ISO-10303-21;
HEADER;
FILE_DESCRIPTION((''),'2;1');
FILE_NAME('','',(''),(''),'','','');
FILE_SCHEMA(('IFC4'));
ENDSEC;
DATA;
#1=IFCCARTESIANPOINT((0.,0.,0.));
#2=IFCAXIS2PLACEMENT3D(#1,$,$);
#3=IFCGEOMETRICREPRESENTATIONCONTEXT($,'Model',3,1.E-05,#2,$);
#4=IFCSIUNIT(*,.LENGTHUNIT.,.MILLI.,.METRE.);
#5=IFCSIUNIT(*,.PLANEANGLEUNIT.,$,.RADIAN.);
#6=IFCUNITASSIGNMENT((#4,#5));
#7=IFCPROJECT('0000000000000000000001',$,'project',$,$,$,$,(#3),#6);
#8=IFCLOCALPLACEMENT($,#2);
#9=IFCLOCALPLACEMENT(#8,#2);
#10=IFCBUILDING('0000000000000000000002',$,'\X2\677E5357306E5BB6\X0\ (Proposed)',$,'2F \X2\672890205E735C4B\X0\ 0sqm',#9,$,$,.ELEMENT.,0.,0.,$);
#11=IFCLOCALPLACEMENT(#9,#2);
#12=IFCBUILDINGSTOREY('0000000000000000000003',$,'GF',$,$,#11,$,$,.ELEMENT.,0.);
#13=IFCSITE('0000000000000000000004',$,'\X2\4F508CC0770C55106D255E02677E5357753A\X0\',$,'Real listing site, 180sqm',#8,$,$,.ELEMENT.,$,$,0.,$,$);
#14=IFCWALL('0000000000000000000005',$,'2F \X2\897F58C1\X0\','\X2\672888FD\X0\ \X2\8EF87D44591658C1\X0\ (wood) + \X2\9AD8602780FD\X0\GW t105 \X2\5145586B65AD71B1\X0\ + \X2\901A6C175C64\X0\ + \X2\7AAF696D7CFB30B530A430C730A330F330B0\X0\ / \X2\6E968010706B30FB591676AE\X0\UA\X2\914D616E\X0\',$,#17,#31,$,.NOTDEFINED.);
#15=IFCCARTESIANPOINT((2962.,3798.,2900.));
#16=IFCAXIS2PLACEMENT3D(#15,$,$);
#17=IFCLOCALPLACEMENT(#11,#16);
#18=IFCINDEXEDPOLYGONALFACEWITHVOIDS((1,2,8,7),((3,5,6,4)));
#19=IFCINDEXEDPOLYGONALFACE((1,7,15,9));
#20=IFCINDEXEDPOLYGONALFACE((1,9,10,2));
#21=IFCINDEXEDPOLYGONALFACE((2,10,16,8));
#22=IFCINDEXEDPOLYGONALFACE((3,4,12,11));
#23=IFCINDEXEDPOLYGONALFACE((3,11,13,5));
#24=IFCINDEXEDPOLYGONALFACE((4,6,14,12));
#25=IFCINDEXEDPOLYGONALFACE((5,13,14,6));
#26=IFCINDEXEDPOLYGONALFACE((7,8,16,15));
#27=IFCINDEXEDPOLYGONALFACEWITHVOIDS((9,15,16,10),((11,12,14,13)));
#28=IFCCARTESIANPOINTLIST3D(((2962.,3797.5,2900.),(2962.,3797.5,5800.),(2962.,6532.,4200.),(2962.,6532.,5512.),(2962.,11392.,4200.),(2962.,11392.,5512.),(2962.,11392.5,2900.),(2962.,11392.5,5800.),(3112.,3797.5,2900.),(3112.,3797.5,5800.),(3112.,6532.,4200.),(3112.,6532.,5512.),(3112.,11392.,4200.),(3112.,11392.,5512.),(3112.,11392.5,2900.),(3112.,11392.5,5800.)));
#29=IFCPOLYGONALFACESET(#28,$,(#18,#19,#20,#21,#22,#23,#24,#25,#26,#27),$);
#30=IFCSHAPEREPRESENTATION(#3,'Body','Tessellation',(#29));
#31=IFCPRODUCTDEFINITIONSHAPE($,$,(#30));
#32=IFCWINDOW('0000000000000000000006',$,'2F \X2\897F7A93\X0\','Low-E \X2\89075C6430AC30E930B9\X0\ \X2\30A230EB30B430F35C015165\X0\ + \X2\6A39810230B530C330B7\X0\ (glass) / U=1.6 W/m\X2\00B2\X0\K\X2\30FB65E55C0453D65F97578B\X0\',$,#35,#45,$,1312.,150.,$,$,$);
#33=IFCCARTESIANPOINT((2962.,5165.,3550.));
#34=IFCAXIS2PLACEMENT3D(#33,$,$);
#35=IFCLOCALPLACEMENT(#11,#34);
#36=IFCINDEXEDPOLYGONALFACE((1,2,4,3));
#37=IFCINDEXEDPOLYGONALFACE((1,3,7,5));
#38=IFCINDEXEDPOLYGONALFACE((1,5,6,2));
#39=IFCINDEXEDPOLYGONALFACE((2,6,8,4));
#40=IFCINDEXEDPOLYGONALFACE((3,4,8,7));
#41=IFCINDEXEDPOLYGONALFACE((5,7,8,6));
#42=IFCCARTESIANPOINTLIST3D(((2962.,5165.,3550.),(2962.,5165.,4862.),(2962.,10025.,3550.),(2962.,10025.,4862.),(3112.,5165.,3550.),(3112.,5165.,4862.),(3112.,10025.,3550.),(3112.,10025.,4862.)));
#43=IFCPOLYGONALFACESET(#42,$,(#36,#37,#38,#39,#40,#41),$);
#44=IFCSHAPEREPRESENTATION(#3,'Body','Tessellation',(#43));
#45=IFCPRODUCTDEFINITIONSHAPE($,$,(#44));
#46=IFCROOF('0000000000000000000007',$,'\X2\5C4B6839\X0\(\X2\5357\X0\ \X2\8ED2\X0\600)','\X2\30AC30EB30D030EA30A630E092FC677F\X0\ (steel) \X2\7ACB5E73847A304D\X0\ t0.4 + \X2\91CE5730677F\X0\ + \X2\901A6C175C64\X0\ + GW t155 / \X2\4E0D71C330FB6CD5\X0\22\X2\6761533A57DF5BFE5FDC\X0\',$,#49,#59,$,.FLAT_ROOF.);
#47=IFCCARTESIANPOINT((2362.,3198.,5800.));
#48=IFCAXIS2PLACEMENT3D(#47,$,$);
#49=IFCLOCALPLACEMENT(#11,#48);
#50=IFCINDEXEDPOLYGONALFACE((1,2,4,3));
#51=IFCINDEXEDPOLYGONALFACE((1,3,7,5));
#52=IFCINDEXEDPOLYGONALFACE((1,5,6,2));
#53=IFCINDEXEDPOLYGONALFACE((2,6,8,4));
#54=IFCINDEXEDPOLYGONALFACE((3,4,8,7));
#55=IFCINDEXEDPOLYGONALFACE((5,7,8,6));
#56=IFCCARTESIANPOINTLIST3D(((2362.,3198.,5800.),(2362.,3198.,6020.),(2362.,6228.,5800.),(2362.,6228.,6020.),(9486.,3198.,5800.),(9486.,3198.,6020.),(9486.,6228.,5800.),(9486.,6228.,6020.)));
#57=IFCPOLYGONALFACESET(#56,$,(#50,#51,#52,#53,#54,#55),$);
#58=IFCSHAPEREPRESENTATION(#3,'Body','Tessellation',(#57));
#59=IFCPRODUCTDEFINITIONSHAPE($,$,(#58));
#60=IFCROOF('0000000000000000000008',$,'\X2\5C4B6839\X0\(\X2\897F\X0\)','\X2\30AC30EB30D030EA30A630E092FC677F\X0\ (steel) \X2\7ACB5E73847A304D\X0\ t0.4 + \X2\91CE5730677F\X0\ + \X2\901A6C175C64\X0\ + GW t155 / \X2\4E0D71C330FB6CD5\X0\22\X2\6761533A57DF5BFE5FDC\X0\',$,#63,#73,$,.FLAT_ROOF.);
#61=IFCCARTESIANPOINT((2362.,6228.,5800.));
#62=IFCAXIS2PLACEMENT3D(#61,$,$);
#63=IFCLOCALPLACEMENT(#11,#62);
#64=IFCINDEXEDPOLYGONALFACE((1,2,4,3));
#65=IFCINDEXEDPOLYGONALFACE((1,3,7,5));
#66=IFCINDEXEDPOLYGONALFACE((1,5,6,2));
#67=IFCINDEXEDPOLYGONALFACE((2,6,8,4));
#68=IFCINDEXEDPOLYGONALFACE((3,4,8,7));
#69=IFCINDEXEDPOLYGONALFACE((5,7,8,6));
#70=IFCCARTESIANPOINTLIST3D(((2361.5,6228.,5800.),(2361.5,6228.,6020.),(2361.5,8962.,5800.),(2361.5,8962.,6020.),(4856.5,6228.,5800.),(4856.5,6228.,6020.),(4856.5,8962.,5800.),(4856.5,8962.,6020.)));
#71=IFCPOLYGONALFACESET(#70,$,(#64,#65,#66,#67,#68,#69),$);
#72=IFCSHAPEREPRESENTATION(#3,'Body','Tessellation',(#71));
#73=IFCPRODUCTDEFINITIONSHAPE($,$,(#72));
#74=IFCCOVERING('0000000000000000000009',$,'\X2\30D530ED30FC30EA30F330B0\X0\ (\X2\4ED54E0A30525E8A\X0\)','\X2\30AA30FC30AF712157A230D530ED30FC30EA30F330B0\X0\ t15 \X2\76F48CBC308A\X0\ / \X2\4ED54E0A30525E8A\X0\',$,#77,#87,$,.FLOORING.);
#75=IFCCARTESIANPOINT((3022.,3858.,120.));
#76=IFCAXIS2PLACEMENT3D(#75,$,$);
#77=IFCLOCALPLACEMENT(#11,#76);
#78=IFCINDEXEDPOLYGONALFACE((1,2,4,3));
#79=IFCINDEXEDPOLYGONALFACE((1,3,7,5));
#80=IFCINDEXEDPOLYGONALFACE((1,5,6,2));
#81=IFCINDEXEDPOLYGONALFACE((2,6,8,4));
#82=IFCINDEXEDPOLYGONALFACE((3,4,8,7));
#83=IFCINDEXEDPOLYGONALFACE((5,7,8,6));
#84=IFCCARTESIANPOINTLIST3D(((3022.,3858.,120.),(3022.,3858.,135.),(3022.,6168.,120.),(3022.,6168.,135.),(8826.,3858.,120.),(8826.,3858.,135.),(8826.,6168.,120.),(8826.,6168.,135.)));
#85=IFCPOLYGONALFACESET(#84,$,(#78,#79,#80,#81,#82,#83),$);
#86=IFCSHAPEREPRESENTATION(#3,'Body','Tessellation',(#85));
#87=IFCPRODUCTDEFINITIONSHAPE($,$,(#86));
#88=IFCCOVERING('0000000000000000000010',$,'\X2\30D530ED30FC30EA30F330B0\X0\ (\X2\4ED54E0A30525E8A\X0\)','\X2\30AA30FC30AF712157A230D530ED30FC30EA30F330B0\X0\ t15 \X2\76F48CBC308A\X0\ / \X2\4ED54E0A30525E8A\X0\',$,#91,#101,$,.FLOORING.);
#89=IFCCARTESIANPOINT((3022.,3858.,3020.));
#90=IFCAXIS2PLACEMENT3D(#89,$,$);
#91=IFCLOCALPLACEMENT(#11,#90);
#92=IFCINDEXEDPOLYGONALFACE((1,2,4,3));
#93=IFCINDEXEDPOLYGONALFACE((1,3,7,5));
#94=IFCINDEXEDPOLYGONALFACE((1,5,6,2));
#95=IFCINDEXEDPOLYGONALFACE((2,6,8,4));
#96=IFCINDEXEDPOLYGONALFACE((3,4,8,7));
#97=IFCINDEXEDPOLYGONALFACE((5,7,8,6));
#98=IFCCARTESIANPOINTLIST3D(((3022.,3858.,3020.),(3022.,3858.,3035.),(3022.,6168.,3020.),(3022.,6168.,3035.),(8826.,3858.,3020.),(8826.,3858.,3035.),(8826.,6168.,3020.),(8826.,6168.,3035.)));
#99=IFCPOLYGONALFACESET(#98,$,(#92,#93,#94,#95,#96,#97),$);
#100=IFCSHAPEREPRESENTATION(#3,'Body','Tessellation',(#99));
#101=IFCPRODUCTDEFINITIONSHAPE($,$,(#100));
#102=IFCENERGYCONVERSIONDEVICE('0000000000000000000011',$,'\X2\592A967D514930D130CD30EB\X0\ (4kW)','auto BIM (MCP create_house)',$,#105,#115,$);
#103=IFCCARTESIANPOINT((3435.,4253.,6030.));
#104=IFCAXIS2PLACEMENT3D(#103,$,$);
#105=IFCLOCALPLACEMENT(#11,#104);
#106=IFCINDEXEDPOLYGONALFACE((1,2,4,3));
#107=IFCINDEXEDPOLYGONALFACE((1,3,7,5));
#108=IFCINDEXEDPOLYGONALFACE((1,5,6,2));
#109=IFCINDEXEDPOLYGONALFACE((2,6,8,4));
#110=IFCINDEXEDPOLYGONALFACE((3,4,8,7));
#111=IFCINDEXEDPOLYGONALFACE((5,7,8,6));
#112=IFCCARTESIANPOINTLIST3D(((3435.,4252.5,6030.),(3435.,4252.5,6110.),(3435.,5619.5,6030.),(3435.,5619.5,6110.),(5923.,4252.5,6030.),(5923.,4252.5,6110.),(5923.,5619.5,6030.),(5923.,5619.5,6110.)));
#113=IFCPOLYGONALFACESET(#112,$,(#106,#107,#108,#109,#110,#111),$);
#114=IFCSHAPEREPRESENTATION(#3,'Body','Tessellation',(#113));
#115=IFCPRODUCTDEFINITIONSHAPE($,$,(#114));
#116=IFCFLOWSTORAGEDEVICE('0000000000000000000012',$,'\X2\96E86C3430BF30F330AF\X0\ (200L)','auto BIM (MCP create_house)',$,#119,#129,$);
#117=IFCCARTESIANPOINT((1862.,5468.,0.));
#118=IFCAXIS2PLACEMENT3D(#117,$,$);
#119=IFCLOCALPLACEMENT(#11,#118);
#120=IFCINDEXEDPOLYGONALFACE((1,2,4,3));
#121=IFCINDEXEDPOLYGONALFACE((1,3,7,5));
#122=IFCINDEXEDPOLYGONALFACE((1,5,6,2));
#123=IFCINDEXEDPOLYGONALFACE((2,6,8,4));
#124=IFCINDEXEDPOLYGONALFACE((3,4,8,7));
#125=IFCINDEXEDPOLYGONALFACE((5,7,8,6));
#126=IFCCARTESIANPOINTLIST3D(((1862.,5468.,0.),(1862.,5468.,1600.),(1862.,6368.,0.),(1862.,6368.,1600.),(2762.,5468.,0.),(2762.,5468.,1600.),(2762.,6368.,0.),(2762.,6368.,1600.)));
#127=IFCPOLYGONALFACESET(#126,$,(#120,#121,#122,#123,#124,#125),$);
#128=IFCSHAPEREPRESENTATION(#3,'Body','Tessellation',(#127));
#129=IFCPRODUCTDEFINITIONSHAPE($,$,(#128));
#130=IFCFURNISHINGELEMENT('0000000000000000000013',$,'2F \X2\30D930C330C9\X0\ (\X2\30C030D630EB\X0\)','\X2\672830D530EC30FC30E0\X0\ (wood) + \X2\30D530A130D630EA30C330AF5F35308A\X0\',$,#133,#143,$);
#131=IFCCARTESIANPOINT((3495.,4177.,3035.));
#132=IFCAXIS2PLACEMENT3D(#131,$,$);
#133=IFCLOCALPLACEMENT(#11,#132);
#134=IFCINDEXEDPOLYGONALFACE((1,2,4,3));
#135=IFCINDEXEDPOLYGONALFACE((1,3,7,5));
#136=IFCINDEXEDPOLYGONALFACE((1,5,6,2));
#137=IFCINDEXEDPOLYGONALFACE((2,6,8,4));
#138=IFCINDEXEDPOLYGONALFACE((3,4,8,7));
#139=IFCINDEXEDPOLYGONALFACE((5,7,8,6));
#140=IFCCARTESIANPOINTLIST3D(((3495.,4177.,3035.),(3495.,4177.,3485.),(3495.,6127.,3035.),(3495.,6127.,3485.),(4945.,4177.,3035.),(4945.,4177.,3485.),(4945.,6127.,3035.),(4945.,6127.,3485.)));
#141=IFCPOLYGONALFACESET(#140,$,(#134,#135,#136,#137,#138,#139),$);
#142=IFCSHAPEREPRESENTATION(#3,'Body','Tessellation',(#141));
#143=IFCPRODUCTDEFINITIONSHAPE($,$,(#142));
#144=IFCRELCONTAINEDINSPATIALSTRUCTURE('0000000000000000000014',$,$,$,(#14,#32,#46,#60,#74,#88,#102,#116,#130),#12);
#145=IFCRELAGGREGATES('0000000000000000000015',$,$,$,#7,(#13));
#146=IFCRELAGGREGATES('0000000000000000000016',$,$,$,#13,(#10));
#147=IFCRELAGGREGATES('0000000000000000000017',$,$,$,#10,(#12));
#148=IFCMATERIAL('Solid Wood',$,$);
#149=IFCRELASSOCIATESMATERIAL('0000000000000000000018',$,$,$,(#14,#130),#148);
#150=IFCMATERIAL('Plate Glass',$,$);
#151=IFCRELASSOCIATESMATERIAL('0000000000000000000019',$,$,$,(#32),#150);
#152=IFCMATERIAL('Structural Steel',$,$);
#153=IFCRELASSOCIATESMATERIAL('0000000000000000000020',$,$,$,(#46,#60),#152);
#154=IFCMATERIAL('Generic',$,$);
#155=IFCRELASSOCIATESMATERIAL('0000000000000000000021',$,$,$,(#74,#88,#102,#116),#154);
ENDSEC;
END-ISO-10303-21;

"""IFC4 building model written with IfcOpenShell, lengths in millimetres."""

from ifc_helpers import new_model, si_unit, frame, frame_2d, origin, place, context, project, spatial, rectangle, extrude, material, element, fill, save


model = new_model("IFC4")

# Units and contexts
model_context = context("Model", 3, precision=1e-05, world=origin())
ifc_project = project(units=[si_unit("LENGTHUNIT", "METRE", prefix="MILLI"), si_unit("PLANEANGLEUNIT", "RADIAN")], contexts=[model_context])

# Site, building, storey
site_placement = place(None, origin())
site = spatial("IfcSite", under=ifc_project, at=site_placement, Name="佐賀県唐津市松南町", ObjectType="Real listing site, 180sqm", CompositionType="ELEMENT", RefElevation=0.0)
building_placement = place(site_placement, origin())
building = spatial("IfcBuilding", under=site, at=building_placement, Name="松南の家 (Proposed)", ObjectType="2F 木造平屋 0sqm", CompositionType="ELEMENT", ElevationOfRefHeight=0.0, ElevationOfTerrain=0.0)
storey_placement = place(building_placement, origin())
storey = spatial("IfcBuildingStorey", under=building, at=storey_placement, Name="GF", CompositionType="ELEMENT", Elevation=0.0)

# Shared definitions
ifc_material_1 = material(Name="Solid Wood")

# Shared definitions
ifc_material_2 = material(Name="Plate Glass")

# Wall, opening, window
wall_1_placement = place(storey_placement, frame((2962.0, 3798.0, 2900.0)))
wall_1 = element("IfcWall", 1, at=wall_1_placement, inside=storey, material=ifc_material_1, Name="2F 西壁", Description="木製 軸組外壁 (wood) + 高性能GW t105 充填断熱 + 通気層 + 窯業系サイディング / 準耐火・外皮UA配慮", PredefinedType="NOTDEFINED", context=model_context, shape_type="SweptSolid", body=[
    extrude(rectangle(XDim=150.0, YDim=7595.0, at=frame_2d((75.0, 3797.0))), frame((2962.0, 3798.0, 2900.0)), (0.0, 0.0, 1.0), 2900.0),
])
opening_1_placement = place(storey_placement, frame((2962.0, 5165.0, 3550.0)))
opening_1 = element("IfcOpeningElement", 2, at=opening_1_placement, cuts=wall_1, PredefinedType="NOTDEFINED", context=model_context, shape_type="SweptSolid", body=[
    extrude(rectangle(XDim=150.0, YDim=4860.0, at=frame_2d((75.0, 2430.0))), frame((2962.0, 5165.0, 3550.0)), (0.0, 0.0, 1.0), 1312.0),
])
window_1_placement = place(storey_placement, frame((2962.0, 5165.0, 3550.0)))
window_1 = element("IfcWindow", 3, at=window_1_placement, inside=storey, material=ifc_material_2, Name="2F 西窓", Description="Low-E 複層ガラス アルゴン封入 + 樹脂サッシ (glass) / U=1.6 W/m²K・日射取得型", OverallHeight=1312.0, OverallWidth=150.0, context=model_context, shape_type="SweptSolid", body=[
    extrude(rectangle(XDim=150.0, YDim=4860.0, at=frame_2d((75.0, 2430.0))), frame((2962.0, 5165.0, 3550.0)), (0.0, 0.0, 1.0), 1312.0),
])
fill(opening_1, window_1)

# Roofs
ifc_material_3 = material(Name="Structural Steel")
roof_1_placement = place(storey_placement, frame((2362.0, 3198.0, 5800.0)))
element("IfcRoof", 4, at=roof_1_placement, inside=storey, material=ifc_material_3, Name="屋根(南 軒600)", Description="ガルバリウム鋼板 (steel) 立平葺き t0.4 + 野地板 + 通気層 + GW t155 / 不燃・法22条区域対応", PredefinedType="FLAT_ROOF", context=model_context, shape_type="SweptSolid", body=[
    extrude(rectangle(XDim=7124.0, YDim=3030.0, at=frame_2d((3562.0, 1515.0))), frame((2362.0, 3198.0, 5800.0)), (0.0, 0.0, 1.0), 220.0),
])
roof_2_placement = place(storey_placement, frame((2362.0, 6228.0, 5800.0)))
element("IfcRoof", 5, at=roof_2_placement, inside=storey, material=ifc_material_3, Name="屋根(西)", Description="ガルバリウム鋼板 (steel) 立平葺き t0.4 + 野地板 + 通気層 + GW t155 / 不燃・法22条区域対応", PredefinedType="FLAT_ROOF", context=model_context, shape_type="SweptSolid", body=[
    extrude(rectangle(XDim=2495.0, YDim=2734.0, at=frame_2d((1247.0, 1367.0))), frame((2362.0, 6228.0, 5800.0)), (0.0, 0.0, 1.0), 220.0),
])

# Coverings
ifc_material_4 = material(Name="Generic")
covering_1_placement = place(storey_placement, frame((3022.0, 3858.0, 120.0)))
element("IfcCovering", 6, at=covering_1_placement, inside=storey, material=ifc_material_4, Name="フローリング (仕上げ床)", Description="オーク無垢フローリング t15 直貼り / 仕上げ床", PredefinedType="FLOORING", context=model_context, shape_type="SweptSolid", body=[
    extrude(rectangle(XDim=5804.0, YDim=2310.0, at=frame_2d((2902.0, 1155.0))), frame((3022.0, 3858.0, 120.0)), (0.0, 0.0, 1.0), 15.0),
])
covering_2_placement = place(storey_placement, frame((3022.0, 3858.0, 3020.0)))
element("IfcCovering", 7, at=covering_2_placement, inside=storey, material=ifc_material_4, Name="フローリング (仕上げ床)", Description="オーク無垢フローリング t15 直貼り / 仕上げ床", PredefinedType="FLOORING", context=model_context, shape_type="SweptSolid", body=[
    extrude(rectangle(XDim=5804.0, YDim=2310.0, at=frame_2d((2902.0, 1155.0))), frame((3022.0, 3858.0, 3020.0)), (0.0, 0.0, 1.0), 15.0),
])

# Energy conversion device
energy_conversion_device_placement = place(storey_placement, frame((3435.0, 4253.0, 6030.0)))
element("IfcEnergyConversionDevice", 8, at=energy_conversion_device_placement, inside=storey, material=ifc_material_4, Name="太陽光パネル (4kW)", Description="auto BIM (MCP create_house)", context=model_context, shape_type="SweptSolid", body=[
    extrude(rectangle(XDim=2488.0, YDim=1367.0, at=frame_2d((1244.0, 683.0))), frame((3435.0, 4253.0, 6030.0)), (0.0, 0.0, 1.0), 80.0),
])

# Flow storage device
flow_storage_device_placement = place(storey_placement, frame((1862.0, 5468.0, 0.0)))
element("IfcFlowStorageDevice", 9, at=flow_storage_device_placement, inside=storey, material=ifc_material_4, Name="雨水タンク (200L)", Description="auto BIM (MCP create_house)", context=model_context, shape_type="SweptSolid", body=[
    extrude(rectangle(XDim=900.0, YDim=900.0, at=frame_2d((450.0, 450.0))), frame((1862.0, 5468.0, 0.0)), (0.0, 0.0, 1.0), 1600.0),
])

# Furnishing element
furnishing_placement = place(storey_placement, frame((3495.0, 4177.0, 3035.0)))
element("IfcFurnishingElement", 10, at=furnishing_placement, inside=storey, material=ifc_material_1, Name="2F ベッド (ダブル)", Description="木フレーム (wood) + ファブリック張り", context=model_context, shape_type="SweptSolid", body=[
    extrude(rectangle(XDim=1450.0, YDim=1950.0, at=frame_2d((725.0, 975.0))), frame((3495.0, 4177.0, 3035.0)), (0.0, 0.0, 1.0), 450.0),
])

save(model, "model.ifc")
